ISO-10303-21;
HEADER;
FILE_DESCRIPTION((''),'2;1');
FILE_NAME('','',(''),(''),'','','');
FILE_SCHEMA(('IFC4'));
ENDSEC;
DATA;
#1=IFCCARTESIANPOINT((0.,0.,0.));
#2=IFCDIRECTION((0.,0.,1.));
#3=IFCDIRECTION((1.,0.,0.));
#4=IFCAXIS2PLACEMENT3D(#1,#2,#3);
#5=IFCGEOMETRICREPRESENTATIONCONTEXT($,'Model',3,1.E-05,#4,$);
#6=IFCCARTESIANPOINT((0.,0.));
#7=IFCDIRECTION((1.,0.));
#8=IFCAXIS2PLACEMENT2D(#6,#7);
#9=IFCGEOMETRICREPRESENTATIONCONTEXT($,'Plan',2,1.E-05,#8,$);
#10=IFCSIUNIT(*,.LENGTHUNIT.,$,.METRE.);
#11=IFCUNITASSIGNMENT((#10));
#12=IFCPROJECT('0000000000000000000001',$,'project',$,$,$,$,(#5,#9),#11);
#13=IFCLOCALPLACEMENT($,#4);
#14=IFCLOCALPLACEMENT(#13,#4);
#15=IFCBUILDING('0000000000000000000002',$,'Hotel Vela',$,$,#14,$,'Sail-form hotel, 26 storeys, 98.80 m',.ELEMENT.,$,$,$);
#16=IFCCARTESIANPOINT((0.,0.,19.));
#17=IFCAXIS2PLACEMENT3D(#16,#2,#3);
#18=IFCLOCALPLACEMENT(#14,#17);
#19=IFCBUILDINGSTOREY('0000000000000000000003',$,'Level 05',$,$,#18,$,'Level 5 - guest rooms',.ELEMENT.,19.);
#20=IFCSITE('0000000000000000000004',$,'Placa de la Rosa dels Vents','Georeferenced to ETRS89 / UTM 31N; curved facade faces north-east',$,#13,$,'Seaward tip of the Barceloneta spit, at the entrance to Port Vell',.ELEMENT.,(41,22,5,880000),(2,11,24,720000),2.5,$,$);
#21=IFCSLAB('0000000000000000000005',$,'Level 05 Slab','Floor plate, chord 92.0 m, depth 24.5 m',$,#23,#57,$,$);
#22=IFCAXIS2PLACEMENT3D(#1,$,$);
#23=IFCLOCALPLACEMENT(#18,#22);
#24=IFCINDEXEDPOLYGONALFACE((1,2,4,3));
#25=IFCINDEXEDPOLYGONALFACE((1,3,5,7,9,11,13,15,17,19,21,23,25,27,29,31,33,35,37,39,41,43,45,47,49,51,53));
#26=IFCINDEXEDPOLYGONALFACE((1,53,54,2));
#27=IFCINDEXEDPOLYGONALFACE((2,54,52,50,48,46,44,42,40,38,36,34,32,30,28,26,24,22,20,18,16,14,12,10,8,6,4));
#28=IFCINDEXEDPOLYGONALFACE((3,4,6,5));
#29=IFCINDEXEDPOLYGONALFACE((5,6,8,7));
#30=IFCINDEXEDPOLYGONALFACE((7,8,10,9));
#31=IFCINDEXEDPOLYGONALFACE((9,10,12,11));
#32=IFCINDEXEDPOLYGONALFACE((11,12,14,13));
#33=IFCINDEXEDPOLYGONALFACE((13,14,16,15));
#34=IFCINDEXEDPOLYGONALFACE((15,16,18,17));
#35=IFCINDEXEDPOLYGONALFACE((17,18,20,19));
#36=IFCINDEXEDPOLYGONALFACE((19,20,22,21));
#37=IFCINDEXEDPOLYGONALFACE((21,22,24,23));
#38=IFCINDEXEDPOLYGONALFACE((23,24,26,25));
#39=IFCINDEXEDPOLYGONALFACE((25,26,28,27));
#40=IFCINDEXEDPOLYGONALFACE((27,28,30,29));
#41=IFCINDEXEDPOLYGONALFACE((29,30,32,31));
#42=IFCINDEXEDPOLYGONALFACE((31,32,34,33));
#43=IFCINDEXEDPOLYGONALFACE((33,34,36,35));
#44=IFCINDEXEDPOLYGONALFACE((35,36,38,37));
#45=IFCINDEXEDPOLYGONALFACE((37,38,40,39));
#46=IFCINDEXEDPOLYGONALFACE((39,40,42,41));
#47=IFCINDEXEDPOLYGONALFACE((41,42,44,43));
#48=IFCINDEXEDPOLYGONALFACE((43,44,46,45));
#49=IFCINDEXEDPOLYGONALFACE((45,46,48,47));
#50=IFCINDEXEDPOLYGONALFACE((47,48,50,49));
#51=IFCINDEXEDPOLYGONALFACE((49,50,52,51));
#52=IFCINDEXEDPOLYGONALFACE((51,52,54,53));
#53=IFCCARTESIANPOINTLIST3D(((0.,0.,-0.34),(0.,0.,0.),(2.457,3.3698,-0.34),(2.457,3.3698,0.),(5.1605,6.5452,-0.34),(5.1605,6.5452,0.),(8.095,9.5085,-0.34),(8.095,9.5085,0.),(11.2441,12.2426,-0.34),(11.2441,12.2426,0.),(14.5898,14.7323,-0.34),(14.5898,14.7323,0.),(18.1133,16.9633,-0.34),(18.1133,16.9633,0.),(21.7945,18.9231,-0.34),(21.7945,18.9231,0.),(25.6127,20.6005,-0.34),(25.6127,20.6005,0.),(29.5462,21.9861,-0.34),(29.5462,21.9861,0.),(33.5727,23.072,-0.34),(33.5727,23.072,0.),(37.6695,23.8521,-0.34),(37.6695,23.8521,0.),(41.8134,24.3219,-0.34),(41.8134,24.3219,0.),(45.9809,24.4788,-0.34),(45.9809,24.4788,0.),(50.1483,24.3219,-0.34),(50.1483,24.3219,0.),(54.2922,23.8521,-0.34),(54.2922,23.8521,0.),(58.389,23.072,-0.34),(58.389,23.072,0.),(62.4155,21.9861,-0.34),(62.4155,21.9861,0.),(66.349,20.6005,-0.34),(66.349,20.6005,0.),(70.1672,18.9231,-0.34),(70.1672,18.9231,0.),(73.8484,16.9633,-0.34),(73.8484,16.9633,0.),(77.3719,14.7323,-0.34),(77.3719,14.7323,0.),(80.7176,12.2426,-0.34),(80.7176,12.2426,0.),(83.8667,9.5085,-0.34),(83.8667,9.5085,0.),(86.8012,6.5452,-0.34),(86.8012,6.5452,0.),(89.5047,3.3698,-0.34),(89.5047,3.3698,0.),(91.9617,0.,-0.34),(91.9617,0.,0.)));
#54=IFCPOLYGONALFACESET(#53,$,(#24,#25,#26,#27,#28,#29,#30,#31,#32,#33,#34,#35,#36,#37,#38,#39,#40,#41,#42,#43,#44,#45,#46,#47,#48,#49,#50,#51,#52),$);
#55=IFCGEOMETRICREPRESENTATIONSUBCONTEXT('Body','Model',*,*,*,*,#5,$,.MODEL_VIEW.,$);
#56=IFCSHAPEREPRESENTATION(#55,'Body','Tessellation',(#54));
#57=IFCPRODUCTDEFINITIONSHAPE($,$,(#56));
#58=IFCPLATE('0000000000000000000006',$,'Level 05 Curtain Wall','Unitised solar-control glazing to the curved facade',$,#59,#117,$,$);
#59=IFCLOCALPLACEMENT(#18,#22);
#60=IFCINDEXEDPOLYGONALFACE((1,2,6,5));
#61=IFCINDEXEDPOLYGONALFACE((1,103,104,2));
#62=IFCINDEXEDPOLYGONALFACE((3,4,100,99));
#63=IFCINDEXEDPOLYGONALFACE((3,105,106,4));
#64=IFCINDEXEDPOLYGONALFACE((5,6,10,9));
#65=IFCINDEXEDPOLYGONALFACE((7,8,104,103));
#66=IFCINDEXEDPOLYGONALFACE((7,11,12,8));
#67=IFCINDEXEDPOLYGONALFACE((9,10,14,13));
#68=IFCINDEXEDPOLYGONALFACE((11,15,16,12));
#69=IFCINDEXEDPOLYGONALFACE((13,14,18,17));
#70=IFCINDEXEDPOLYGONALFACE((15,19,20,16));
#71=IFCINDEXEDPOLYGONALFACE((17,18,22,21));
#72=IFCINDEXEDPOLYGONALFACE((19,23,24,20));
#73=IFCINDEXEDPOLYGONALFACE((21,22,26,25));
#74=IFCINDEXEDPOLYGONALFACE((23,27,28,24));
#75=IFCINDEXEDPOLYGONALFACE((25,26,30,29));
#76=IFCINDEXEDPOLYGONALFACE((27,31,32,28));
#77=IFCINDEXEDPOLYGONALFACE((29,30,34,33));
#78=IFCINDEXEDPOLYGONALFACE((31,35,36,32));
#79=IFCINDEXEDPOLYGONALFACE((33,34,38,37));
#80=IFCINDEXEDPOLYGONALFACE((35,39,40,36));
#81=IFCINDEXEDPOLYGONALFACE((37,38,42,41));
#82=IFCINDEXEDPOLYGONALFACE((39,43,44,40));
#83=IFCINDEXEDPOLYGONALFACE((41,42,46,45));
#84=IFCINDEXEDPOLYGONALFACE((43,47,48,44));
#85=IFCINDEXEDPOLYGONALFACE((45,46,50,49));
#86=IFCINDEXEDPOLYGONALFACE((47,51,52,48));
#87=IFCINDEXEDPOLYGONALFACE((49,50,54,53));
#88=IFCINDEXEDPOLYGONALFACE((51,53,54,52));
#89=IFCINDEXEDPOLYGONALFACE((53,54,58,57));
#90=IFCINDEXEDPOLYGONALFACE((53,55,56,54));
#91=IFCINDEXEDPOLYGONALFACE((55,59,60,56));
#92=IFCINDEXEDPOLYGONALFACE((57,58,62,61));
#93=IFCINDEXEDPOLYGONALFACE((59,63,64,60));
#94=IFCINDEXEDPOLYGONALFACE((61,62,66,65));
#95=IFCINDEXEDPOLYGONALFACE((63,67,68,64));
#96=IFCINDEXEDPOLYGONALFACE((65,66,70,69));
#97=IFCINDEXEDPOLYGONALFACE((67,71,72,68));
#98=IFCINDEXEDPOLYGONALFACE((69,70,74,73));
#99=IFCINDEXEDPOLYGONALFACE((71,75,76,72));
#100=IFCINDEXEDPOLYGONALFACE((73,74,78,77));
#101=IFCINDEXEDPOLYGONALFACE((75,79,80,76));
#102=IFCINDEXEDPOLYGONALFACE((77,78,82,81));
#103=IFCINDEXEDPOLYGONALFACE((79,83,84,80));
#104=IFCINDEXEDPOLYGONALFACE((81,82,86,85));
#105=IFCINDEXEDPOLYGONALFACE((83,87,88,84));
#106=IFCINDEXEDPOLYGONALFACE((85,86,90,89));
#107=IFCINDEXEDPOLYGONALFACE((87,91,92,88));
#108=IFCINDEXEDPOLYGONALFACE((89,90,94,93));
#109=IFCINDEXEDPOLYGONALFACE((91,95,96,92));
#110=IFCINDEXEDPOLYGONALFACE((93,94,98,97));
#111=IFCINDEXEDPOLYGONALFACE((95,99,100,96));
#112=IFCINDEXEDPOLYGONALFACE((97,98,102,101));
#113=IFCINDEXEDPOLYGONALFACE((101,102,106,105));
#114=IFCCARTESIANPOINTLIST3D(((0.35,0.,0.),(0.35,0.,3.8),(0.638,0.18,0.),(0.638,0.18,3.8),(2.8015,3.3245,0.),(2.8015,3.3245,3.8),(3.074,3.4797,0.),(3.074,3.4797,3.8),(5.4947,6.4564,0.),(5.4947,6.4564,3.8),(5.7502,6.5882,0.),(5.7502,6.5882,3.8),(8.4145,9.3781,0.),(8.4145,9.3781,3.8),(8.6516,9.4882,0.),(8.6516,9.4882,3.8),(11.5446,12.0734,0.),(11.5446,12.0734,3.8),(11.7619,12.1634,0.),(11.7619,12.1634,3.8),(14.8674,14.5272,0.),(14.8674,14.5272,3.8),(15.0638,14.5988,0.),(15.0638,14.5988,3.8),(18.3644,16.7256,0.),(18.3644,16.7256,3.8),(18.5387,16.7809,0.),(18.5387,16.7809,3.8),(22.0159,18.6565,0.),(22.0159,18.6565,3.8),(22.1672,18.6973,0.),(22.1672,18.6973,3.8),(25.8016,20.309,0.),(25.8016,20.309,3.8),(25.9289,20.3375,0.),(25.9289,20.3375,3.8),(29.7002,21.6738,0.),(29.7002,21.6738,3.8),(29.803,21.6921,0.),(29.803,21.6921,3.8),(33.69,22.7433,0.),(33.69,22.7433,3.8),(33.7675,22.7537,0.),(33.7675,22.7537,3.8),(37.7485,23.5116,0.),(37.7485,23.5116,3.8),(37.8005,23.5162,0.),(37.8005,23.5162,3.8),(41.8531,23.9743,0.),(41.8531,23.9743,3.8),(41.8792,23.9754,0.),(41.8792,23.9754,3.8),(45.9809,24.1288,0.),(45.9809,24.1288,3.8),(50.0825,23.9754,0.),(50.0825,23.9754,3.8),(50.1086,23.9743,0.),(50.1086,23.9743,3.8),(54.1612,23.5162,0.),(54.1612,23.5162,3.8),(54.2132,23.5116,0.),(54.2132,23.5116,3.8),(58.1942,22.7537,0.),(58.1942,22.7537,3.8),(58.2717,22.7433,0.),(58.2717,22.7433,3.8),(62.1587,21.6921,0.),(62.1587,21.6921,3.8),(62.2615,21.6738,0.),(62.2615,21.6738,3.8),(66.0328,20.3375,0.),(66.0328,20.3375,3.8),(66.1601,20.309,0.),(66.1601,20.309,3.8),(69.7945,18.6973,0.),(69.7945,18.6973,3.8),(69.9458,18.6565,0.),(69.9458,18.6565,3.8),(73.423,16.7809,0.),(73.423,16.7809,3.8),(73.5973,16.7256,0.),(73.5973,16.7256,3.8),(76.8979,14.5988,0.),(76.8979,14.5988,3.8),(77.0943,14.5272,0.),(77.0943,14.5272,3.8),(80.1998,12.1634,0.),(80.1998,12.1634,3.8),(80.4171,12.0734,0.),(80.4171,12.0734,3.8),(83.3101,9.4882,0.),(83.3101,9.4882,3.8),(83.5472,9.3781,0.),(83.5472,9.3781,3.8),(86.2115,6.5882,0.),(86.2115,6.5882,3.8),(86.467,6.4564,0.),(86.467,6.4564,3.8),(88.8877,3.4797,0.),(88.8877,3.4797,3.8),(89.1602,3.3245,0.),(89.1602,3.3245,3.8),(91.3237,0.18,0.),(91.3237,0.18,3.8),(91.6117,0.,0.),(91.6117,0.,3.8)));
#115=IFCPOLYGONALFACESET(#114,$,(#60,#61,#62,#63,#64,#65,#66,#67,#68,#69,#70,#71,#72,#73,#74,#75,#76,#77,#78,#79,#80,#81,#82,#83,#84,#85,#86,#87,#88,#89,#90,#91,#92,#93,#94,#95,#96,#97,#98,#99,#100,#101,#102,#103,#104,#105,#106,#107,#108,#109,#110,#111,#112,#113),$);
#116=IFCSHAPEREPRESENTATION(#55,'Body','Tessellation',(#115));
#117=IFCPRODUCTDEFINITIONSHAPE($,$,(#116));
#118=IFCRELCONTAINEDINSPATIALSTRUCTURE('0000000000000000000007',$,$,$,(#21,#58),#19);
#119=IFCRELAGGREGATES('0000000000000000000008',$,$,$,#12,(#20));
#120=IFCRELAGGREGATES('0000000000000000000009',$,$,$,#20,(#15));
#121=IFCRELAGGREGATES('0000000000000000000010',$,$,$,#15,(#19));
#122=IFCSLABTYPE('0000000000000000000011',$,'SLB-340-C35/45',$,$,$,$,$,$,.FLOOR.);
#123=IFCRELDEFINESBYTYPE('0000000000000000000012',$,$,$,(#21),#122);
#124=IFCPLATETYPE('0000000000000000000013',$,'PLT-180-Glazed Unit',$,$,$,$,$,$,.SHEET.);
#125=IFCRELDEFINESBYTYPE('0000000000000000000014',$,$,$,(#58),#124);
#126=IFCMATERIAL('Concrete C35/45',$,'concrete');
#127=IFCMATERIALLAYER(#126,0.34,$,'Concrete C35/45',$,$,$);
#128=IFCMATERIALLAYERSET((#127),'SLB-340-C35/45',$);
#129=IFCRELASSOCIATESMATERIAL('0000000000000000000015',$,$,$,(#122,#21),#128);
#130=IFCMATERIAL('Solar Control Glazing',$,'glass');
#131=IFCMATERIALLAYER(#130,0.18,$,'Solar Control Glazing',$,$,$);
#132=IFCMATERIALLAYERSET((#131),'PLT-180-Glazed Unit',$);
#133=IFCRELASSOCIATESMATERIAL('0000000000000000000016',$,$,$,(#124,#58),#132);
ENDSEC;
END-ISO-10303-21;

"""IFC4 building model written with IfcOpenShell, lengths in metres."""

from ifc_helpers import new_model, si_unit, frame, origin_with_axes, origin_2d_with_axis, place, context, subcontext, project, spatial, line, indexed_curve, outline, extrude, material, layer, layer_set, layer_usage, type_object, element, save


model = new_model("IFC4")

# Units and contexts
model_context = context("Model", 3, precision=1e-05, world=origin_with_axes())
plan_context = context("Plan", 2, precision=1e-05, world=origin_2d_with_axis())
body_context = subcontext(model_context, "Body", "Model", "MODEL_VIEW")
ifc_project = project(units=[si_unit("LENGTHUNIT", "METRE")], contexts=[model_context, plan_context])

# Site, building, storey
site_placement = place(None, origin_with_axes())
site = spatial("IfcSite", under=ifc_project, at=site_placement, Name="Placa de la Rosa dels Vents", Description="Georeferenced to ETRS89 / UTM 31N; curved facade faces north-east", LongName="Seaward tip of the Barceloneta spit, at the entrance to Port Vell", CompositionType="ELEMENT", RefLatitude=(41, 22, 5, 880000), RefLongitude=(2, 11, 24, 720000), RefElevation=2.5)
building_placement = place(site_placement, origin_with_axes())
building = spatial("IfcBuilding", under=site, at=building_placement, Name="Hotel Vela", LongName="Sail-form hotel, 26 storeys, 98.80 m", CompositionType="ELEMENT")
storey_placement = place(building_placement, frame((0.0, 0.0, 19.0), z_axis=(0.0, 0.0, 1.0), x_axis=(1.0, 0.0, 0.0)))
storey = spatial("IfcBuildingStorey", under=building, at=storey_placement, Name="Level 05", LongName="Level 5 - guest rooms", CompositionType="ELEMENT", Elevation=19.0)

# Slab
ifc_material_1 = material(Name="Concrete C35/45", Category="concrete")
ifc_layer_1 = layer(ifc_material_1, 0.34, Name="Concrete C35/45")
ifc_layer_set_1 = layer_set([ifc_layer_1], Name="SLB-340-C35/45")
ifc_layer_usage_1 = layer_usage(ifc_layer_set_1, "AXIS3", "POSITIVE", 0.0)
slab_type = type_object("IfcSlabType", Name="SLB-340-C35/45", PredefinedType="FLOOR", material=ifc_layer_set_1)
slab_placement = place(storey_placement, frame((0.0, 0.0, -0.34), z_axis=(0.0, 0.0, 1.0), x_axis=(1.0, 0.0, 0.0)))
element("IfcSlab", 1, at=slab_placement, inside=storey, type_object=slab_type, material=ifc_layer_usage_1, Name="Level 05 Slab", Description="Floor plate, chord 92.0 m, depth 24.5 m", context=body_context, shape_type="SweptSolid", body=[
    extrude(outline(indexed_curve([(0.0, 0.0), (91.9617, 0.0), (89.5047, 3.3698), (86.8012, 6.5452), (83.8667, 9.5085), (80.7176, 12.2426), (77.3719, 14.7323), (73.8484, 16.9633), (70.1672, 18.9231), (66.349, 20.6005), (62.4155, 21.9861), (58.389, 23.072), (54.2922, 23.8521), (50.1483, 24.3219), (45.9809, 24.4788), (41.8134, 24.3219), (37.6695, 23.8521), (33.5727, 23.072), (29.5462, 21.9861), (25.6127, 20.6005), (21.7945, 18.9231), (18.1133, 16.9633), (14.5898, 14.7323), (11.2441, 12.2426), (8.095, 9.5085), (5.1605, 6.5452), (2.457, 3.3698)], segments=[line(1, 2, 3, 4, 5, 6, 7, 8, 9, 10, 11, 12, 13, 14, 15, 16, 17, 18, 19, 20, 21, 22, 23, 24, 25, 26, 27, 1)])), origin_with_axes(), (0.0, 0.0, 1.0), 0.34),
])

# Plate
ifc_material_2 = material(Name="Solar Control Glazing", Category="glass")
ifc_layer_2 = layer(ifc_material_2, 0.18, Name="Solar Control Glazing")
ifc_layer_set_2 = layer_set([ifc_layer_2], Name="PLT-180-Glazed Unit")
ifc_layer_usage_2 = layer_usage(ifc_layer_set_2, "AXIS2", "POSITIVE", 0.0)
plate_type_1 = type_object("IfcPlateType", Name="PLT-180-Glazed Unit", PredefinedType="SHEET", material=ifc_layer_set_2)
plate_1_placement = place(storey_placement, frame((0.35, 0.0, 0.0), z_axis=(0.0, 0.0, 1.0), x_axis=(1.0, 0.0, 0.0)))
element("IfcPlate", 2, at=plate_1_placement, inside=storey, type_object=plate_type_1, material=ifc_layer_usage_2, Name="Level 05 Curtain Wall", Description="Unitised solar-control glazing to the curved facade", context=body_context, shape_type="SweptSolid", body=[
    extrude(outline(indexed_curve([(91.2617, 0.0), (88.8102, 3.3245), (86.117, 6.4564), (83.1972, 9.3781), (80.0671, 12.0734), (76.7443, 14.5272), (73.2473, 16.7256), (69.5958, 18.6565), (65.8101, 20.309), (61.9115, 21.6738), (57.9217, 22.7433), (53.8632, 23.5116), (49.7586, 23.9743), (45.6309, 24.1288), (41.5031, 23.9743), (37.3985, 23.5116), (33.34, 22.7433), (29.3502, 21.6738), (25.4516, 20.309), (21.6659, 18.6565), (18.0144, 16.7256), (14.5174, 14.5272), (11.1946, 12.0734), (8.0645, 9.3781), (5.1447, 6.4564), (2.4515, 3.3245), (0.0, 0.0), (90.9737, 0.18), (2.724, 3.4797), (5.4002, 6.5882), (8.3016, 9.4882), (11.4119, 12.1634), (14.7138, 14.5988), (18.1887, 16.7809), (21.8172, 18.6973), (25.5789, 20.3375), (29.453, 21.6921), (33.4175, 22.7537), (37.4505, 23.5162), (41.5292, 23.9754), (45.6309, 24.1288), (49.7325, 23.9754), (53.8112, 23.5162), (57.8442, 22.7537), (61.8087, 21.6921), (65.6828, 20.3375), (69.4445, 18.6973), (73.073, 16.7809), (76.5479, 14.5988), (79.8498, 12.1634), (82.9601, 9.4882), (85.8615, 6.5882), (88.5377, 3.4797), (0.288, 0.18)], segments=[line(1, 2, 3, 4, 5, 6, 7, 8, 9, 10, 11, 12, 13, 14, 15, 16, 17, 18, 19, 20, 21, 22, 23, 24, 25, 26, 27, 28, 29, 30, 31, 32, 33, 34, 35, 36, 37, 38, 39, 40, 41, 42, 43, 44, 45, 46, 47, 48, 49, 50, 51, 52, 53, 54, 1)])), origin_with_axes(), (0.0, 0.0, 1.0), 3.8),
])

save(model, "model.ifc")
